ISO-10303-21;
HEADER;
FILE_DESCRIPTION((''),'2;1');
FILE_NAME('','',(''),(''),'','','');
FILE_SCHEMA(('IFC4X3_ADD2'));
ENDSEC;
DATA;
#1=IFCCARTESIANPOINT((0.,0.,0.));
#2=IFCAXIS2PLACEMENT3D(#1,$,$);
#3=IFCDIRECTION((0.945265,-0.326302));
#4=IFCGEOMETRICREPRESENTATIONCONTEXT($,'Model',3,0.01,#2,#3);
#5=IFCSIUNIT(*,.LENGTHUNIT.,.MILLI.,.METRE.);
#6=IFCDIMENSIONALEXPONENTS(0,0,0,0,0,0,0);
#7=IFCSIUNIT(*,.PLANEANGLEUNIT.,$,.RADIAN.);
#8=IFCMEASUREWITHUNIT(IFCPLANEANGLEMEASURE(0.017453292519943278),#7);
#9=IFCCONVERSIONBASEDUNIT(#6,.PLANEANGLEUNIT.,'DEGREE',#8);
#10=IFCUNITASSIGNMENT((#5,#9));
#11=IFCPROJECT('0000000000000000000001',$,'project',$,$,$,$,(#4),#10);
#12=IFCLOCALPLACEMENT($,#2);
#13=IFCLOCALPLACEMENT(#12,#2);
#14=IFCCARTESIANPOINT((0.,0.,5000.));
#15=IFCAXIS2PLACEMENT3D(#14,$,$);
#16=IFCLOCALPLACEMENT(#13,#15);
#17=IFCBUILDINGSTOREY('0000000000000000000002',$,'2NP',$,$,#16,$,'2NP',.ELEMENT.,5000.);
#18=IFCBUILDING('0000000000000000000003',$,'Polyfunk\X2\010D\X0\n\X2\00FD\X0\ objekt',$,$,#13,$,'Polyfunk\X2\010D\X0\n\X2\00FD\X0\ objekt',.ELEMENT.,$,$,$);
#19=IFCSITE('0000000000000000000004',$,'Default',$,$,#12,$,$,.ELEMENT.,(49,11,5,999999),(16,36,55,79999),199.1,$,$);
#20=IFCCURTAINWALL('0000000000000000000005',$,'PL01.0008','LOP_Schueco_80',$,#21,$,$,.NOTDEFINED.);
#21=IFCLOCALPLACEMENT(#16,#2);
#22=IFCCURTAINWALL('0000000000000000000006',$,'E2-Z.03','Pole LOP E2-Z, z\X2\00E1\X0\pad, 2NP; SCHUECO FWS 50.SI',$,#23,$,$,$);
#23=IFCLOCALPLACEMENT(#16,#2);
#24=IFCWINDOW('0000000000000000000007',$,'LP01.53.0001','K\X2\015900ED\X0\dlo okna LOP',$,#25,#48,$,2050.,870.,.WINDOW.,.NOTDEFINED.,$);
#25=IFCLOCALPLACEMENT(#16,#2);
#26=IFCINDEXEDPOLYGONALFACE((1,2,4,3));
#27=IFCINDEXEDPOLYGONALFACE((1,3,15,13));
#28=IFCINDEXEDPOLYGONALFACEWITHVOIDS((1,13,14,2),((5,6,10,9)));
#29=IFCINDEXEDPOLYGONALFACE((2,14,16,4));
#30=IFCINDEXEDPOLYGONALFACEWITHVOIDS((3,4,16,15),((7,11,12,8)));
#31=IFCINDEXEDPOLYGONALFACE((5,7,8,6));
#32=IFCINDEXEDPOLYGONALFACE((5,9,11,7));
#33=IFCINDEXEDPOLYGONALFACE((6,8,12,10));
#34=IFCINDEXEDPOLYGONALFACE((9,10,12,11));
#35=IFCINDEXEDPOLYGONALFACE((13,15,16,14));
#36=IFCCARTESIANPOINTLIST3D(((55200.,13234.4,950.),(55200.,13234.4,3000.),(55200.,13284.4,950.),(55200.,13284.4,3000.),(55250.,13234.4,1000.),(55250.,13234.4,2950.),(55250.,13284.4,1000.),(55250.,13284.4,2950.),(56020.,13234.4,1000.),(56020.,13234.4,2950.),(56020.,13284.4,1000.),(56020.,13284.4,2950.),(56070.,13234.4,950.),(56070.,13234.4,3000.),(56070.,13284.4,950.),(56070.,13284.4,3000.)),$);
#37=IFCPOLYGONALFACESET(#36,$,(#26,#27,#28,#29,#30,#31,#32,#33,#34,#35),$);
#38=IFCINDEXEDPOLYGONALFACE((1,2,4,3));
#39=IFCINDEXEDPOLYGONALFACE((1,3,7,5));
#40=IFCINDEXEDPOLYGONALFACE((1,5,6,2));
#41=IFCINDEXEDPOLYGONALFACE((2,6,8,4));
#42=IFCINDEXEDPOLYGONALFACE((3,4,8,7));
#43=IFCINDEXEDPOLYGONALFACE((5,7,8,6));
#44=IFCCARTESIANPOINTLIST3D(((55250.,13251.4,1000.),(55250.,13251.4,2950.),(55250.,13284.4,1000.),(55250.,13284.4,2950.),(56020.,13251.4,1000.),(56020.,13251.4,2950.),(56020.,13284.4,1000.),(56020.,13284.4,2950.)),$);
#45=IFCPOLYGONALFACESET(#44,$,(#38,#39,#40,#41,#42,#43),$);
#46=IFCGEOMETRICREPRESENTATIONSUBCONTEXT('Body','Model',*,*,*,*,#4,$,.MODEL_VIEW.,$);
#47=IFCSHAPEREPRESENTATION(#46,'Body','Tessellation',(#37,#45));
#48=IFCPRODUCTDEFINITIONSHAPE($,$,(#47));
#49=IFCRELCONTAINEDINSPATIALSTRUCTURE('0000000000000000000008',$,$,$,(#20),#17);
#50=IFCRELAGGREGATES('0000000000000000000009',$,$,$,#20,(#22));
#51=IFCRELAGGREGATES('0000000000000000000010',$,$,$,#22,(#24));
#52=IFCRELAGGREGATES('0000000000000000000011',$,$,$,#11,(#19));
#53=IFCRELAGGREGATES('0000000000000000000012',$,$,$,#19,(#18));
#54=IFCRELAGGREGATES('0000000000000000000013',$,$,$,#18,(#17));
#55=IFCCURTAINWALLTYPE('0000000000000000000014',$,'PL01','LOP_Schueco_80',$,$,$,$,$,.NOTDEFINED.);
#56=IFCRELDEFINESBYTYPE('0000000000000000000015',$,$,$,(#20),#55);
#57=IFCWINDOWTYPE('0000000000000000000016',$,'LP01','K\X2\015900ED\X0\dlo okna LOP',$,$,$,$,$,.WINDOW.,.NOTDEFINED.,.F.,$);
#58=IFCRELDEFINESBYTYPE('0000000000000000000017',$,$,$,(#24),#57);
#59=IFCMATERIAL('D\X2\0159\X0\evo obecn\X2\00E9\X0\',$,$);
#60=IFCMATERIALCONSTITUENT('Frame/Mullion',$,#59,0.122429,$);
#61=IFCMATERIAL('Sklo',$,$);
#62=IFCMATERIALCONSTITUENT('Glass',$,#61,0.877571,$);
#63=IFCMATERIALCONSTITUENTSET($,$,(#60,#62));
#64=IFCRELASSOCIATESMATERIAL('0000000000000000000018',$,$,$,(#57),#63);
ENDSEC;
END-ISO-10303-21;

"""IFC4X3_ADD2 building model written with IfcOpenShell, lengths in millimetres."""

from ifc_helpers import new_model, entity, si_unit, converted_unit, direction, frame, origin, origin_2d_with_axis, place, context, subcontext, project, spatial, polyline, rectangle, outline, extrude, source, transform, mapped, material, constituent, constituent_set, type_object, type_shapes, element, aggregate, save


model = new_model("IFC4X3_ADD2")

# Units and contexts
model_context = context("Model", 3, precision=0.01, world=origin(), true_north=direction((0.945265, -0.326302)))
body_context = subcontext(model_context, "Body", "Model", "MODEL_VIEW")
ifc_project = project(units=[si_unit("LENGTHUNIT", "METRE", prefix="MILLI"), converted_unit("PLANEANGLEUNIT", "DEGREE", entity("IfcPlaneAngleMeasure", 0.017453292519943278), si_unit("PLANEANGLEUNIT", "RADIAN"), dimensions=[0, 0, 0, 0, 0, 0, 0])], contexts=[model_context])

# Site, building, storey
site_placement = place(None, origin())
site = spatial("IfcSite", under=ifc_project, at=site_placement, Name="Default", CompositionType="ELEMENT", RefLatitude=(49, 11, 5, 999999), RefLongitude=(16, 36, 55, 79999), RefElevation=199.1)
building_placement = place(site_placement, origin())
building = spatial("IfcBuilding", under=site, at=building_placement, Name="Polyfunkčný objekt", LongName="Polyfunkčný objekt", CompositionType="ELEMENT")
storey_placement = place(building_placement, frame((0.0, 0.0, 5000.0)))
storey = spatial("IfcBuildingStorey", under=building, at=storey_placement, Name="2NP", LongName="2NP", CompositionType="ELEMENT", Elevation=5000.0)

# Curtain walls
curtain_wall_type = type_object("IfcCurtainWallType", Name="PL01", Description="LOP_Schueco_80", PredefinedType="NOTDEFINED")
curtain_wall_1_placement = place(storey_placement, frame((0.0, 0.0, -5000.0)))
curtain_wall_1 = element("IfcCurtainWall", 1, at=curtain_wall_1_placement, inside=storey, type_object=curtain_wall_type, Name="PL01.0008", Description="LOP_Schueco_80", PredefinedType="NOTDEFINED")
curtain_wall_2 = element("IfcCurtainWall", 2, Name="E2-Z.03", Description="Pole LOP E2-Z, západ, 2NP; SCHUECO FWS 50.SI")
aggregate(curtain_wall_1, [curtain_wall_2])
ifc_material_1 = material(Name="Sklo")

# Window
ifc_material_2 = material(Name="Dřevo obecné")
ifc_constituent_1 = constituent(ifc_material_2, Name="Frame/Mullion", fraction=0.122429)
ifc_constituent_2 = constituent(ifc_material_1, Name="Glass", fraction=0.877571)
ifc_constituent_set = constituent_set(constituents=[ifc_constituent_1, ifc_constituent_2])
window_type = type_object("IfcWindowType", Name="LP01", Description="Křídlo okna LOP", ParameterTakesPrecedence=False, PartitioningType="NOTDEFINED", PredefinedType="WINDOW", material=ifc_constituent_set)
shared_shape_1 = source(origin(), body_context, "Body", "SweptSolid", [
    extrude(outline(polyline([(-1025.0, -435.0), (1025.0, -435.0), (1025.0, 435.0), (-1025.0, 435.0), (-1025.0, -435.0)]), holes=[polyline([(-975.0, -385.0), (-975.0, 385.0), (975.0, 385.0), (975.0, -385.0), (-975.0, -385.0)])]), frame((0.0, 0.0, 1025.0), z_axis=(0.0, 1.0, 0.0), x_axis=(0.0, 0.0, -1.0)), (0.0, 0.0, 1.0), 50.0),
    extrude(rectangle(XDim=33.0, YDim=770.0, at=origin_2d_with_axis()), frame((0.0, 33.5, 50.0), z_axis=(0.0, 0.0, 1.0), x_axis=(0.0, -1.0, 0.0)), (0.0, 0.0, 1.0), 1950.0),
])
type_shapes(window_type, [shared_shape_1])
window_placement = place(curtain_wall_1_placement, frame((55635.0, 13234.4, 5950.0)))
window = element("IfcWindow", 3, at=window_placement, type_object=window_type, Name="LP01.53.0001", Description="Křídlo okna LOP", OverallHeight=2050.0, OverallWidth=870.0, PartitioningType="NOTDEFINED", PredefinedType="WINDOW", context=body_context, shape_type="MappedRepresentation", body=[
    mapped(shared_shape_1, transform((0.0, 0.0, 0.0), scale=1.0)),
])
aggregate(curtain_wall_2, [window])

save(model, "model.ifc")
